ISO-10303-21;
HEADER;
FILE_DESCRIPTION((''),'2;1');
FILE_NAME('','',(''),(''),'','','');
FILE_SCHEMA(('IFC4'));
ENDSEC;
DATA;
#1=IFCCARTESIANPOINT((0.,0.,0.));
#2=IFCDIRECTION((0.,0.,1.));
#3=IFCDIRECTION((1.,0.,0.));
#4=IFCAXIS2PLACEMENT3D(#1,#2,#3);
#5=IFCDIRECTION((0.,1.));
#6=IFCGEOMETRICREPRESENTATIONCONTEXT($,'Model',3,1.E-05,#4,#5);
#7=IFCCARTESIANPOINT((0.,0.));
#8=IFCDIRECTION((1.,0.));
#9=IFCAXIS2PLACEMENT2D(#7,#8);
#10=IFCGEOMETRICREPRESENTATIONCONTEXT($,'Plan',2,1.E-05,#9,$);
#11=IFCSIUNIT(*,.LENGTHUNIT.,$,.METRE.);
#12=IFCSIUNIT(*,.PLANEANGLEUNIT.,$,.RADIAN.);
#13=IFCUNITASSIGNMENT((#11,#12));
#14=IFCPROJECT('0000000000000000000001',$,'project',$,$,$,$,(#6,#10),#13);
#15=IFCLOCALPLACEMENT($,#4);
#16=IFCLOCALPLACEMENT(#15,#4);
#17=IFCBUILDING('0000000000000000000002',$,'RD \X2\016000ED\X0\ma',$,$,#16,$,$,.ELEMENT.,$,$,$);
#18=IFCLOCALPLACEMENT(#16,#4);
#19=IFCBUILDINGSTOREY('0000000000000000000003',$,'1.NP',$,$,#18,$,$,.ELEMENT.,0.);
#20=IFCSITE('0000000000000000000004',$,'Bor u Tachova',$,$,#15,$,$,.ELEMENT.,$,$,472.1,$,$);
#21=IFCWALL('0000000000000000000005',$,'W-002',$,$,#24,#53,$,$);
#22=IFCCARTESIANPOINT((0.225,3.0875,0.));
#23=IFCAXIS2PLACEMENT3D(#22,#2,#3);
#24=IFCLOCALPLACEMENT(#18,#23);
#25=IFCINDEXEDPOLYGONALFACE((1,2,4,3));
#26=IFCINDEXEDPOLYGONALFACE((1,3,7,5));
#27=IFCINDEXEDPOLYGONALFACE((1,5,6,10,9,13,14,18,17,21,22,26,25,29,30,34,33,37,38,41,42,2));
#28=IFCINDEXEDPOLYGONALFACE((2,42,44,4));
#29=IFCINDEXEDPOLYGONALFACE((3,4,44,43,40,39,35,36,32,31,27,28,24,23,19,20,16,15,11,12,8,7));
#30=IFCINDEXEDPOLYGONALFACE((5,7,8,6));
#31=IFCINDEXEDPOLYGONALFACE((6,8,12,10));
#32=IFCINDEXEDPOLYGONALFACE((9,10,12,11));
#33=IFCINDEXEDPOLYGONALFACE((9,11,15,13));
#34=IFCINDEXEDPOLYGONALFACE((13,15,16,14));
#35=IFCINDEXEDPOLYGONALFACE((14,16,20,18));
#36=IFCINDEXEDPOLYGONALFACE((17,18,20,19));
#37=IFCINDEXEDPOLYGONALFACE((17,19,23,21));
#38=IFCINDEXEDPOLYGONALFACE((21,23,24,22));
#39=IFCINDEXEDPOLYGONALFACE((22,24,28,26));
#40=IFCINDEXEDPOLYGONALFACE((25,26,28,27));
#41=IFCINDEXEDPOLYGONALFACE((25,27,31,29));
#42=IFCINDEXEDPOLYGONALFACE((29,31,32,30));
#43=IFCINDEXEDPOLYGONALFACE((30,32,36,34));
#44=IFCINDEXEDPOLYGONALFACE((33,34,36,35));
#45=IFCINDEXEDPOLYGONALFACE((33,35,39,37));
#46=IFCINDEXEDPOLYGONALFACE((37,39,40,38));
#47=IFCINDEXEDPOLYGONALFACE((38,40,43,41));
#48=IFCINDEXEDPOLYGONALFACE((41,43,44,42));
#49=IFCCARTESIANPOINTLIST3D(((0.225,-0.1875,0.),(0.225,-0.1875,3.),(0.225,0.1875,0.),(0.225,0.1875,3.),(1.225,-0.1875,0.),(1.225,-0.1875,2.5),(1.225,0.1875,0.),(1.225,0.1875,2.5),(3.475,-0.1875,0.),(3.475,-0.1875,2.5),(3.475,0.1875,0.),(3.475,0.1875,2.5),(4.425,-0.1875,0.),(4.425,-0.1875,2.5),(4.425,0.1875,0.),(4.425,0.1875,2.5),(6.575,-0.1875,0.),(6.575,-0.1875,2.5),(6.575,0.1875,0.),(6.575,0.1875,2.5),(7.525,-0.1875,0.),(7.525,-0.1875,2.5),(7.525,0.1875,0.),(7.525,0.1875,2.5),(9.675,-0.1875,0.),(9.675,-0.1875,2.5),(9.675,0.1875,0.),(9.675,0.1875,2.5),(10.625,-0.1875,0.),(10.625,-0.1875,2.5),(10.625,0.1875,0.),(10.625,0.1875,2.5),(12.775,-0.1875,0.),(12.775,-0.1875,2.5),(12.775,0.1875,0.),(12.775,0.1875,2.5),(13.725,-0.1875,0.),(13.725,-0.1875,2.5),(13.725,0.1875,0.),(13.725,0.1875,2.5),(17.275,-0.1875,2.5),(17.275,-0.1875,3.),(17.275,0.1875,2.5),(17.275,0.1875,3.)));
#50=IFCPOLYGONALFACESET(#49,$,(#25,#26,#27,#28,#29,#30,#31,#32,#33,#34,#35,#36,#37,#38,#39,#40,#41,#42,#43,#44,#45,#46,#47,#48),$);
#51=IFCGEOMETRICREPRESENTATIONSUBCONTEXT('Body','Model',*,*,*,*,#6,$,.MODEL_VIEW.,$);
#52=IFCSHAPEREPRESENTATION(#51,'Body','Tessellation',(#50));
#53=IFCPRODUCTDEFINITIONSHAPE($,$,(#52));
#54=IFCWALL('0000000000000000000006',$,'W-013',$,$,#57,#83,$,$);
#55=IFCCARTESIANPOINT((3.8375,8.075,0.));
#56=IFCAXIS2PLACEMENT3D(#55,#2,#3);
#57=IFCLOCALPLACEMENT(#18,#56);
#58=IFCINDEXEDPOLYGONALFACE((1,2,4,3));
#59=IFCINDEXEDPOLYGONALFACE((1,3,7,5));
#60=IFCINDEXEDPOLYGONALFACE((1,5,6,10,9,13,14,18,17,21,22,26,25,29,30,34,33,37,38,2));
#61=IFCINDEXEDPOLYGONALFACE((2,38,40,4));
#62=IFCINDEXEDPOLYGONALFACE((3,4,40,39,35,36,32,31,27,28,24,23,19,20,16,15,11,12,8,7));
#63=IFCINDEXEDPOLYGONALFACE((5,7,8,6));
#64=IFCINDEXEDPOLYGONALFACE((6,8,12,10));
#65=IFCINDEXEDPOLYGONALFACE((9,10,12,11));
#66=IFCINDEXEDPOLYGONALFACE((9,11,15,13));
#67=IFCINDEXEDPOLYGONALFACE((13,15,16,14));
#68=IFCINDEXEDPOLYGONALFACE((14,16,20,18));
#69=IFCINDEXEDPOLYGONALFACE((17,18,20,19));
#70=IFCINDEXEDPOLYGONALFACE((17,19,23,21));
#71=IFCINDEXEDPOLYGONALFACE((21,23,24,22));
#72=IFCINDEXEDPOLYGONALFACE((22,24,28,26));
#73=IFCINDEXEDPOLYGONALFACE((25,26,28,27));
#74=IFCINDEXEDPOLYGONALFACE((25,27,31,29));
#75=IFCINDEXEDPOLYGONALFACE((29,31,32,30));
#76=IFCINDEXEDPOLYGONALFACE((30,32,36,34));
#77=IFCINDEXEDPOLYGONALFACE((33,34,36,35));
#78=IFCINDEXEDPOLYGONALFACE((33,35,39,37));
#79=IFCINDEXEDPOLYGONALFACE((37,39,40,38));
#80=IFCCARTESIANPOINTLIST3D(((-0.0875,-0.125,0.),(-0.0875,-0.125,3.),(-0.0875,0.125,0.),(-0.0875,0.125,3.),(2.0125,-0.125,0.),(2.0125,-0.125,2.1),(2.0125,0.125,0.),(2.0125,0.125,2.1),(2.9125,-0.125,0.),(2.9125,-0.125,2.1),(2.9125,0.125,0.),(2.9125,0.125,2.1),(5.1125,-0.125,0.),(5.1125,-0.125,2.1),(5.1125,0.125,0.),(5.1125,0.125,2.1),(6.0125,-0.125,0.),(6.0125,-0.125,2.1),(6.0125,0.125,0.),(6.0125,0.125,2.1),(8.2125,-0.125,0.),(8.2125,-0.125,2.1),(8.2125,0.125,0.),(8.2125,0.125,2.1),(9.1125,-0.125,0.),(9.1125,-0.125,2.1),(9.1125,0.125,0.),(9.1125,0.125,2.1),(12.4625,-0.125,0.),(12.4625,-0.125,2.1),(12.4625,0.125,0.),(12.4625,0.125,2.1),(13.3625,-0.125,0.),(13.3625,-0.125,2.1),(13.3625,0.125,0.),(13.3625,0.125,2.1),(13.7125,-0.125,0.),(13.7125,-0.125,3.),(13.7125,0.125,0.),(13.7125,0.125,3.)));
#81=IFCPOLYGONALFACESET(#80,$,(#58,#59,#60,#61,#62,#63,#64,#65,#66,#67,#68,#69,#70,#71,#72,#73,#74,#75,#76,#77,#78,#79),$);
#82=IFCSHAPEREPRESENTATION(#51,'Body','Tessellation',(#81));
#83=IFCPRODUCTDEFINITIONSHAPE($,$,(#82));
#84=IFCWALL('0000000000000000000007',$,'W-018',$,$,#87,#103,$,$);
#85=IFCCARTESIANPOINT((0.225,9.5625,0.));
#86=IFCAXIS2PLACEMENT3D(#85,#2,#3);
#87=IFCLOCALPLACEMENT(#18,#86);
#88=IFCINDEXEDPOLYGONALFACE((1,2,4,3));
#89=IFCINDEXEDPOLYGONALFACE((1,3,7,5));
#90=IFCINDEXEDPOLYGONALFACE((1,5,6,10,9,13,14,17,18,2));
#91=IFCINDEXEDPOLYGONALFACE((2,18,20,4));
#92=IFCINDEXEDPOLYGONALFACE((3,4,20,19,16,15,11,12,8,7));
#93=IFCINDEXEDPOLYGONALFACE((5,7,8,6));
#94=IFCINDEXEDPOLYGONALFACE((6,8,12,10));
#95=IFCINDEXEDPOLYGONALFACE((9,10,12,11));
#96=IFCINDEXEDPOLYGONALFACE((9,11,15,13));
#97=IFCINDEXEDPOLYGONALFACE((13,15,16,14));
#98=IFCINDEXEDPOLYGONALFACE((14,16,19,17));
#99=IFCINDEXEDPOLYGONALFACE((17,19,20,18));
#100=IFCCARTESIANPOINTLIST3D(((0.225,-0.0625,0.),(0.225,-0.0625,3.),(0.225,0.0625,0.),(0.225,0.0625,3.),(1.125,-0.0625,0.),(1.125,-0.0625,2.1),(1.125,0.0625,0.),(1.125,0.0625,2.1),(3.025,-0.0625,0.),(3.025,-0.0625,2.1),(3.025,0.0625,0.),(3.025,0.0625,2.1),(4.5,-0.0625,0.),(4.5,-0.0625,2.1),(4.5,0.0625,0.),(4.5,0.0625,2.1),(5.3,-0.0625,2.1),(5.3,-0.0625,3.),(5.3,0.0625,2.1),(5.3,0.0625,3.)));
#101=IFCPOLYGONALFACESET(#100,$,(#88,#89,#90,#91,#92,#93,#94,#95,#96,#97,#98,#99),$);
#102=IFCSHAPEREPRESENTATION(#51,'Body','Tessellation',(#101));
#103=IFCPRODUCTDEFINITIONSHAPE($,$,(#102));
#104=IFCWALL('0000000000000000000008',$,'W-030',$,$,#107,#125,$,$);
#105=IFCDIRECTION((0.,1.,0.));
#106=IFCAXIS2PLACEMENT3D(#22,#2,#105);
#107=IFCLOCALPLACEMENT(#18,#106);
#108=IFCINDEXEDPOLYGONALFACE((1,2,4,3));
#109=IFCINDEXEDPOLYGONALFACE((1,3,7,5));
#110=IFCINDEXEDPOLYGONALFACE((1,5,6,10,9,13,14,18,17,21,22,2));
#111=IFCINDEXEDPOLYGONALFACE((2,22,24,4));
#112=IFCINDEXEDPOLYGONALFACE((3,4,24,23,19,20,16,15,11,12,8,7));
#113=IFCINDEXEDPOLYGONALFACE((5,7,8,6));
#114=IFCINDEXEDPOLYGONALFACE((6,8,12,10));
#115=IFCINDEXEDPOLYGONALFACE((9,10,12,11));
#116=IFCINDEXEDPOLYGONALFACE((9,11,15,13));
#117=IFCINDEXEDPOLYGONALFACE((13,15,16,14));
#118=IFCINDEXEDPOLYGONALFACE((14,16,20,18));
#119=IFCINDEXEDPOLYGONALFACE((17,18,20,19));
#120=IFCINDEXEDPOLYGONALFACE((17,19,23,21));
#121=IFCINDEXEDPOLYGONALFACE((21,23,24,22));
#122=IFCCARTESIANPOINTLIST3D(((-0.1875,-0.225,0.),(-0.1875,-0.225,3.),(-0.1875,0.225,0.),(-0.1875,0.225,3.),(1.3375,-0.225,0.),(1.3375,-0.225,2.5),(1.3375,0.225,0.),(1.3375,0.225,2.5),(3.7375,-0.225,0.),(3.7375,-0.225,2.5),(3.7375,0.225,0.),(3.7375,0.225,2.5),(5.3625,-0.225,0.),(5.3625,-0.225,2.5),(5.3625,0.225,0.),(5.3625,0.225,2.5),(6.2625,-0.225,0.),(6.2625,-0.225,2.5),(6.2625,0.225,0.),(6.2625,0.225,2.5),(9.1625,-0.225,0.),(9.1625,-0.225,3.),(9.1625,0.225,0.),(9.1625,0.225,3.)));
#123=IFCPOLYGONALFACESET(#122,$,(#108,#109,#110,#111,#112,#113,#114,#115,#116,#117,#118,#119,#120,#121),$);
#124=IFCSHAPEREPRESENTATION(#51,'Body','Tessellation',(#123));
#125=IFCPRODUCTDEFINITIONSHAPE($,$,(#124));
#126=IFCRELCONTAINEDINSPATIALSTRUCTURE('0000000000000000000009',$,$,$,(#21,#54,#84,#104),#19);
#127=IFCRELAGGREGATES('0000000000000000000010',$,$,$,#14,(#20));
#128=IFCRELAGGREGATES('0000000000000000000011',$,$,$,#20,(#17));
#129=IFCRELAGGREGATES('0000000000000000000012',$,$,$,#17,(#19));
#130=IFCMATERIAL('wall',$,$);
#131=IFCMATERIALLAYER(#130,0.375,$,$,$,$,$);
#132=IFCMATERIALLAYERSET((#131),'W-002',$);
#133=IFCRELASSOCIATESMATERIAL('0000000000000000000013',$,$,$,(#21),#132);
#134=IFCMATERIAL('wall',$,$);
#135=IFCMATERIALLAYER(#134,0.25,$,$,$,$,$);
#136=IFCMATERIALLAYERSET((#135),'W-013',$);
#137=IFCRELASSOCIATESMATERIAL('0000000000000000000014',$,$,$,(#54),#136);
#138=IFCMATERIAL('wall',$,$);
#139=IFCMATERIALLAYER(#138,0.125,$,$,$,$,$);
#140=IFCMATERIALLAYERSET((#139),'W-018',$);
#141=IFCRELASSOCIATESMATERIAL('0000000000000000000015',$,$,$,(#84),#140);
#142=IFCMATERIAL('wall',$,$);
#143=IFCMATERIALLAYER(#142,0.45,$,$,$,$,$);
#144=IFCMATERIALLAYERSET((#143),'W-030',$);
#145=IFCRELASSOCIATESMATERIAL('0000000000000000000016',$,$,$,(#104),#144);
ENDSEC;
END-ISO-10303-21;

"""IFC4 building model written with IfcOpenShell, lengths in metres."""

from ifc_helpers import new_model, si_unit, direction, frame, frame_2d, origin_with_axes, origin_2d_with_axis, place, context, subcontext, project, spatial, line, indexed_curve, rectangle, outline, extrude, material, layer, layer_set, layer_usage, element, save


model = new_model("IFC4")

# Units and contexts
model_context = context("Model", 3, precision=1e-05, world=origin_with_axes(), true_north=direction((0.0, 1.0)))
plan_context = context("Plan", 2, precision=1e-05, world=origin_2d_with_axis())
body_context = subcontext(model_context, "Body", "Model", "MODEL_VIEW")
ifc_project = project(units=[si_unit("LENGTHUNIT", "METRE"), si_unit("PLANEANGLEUNIT", "RADIAN")], contexts=[model_context, plan_context])

# Site, building, storey
site_placement = place(None, origin_with_axes())
site = spatial("IfcSite", under=ifc_project, at=site_placement, Name="Bor u Tachova", CompositionType="ELEMENT", RefElevation=472.1)
building_placement = place(site_placement, origin_with_axes())
building = spatial("IfcBuilding", under=site, at=building_placement, Name="RD Šíma", CompositionType="ELEMENT")
storey_placement = place(building_placement, origin_with_axes())
storey = spatial("IfcBuildingStorey", under=building, at=storey_placement, Name="1.NP", CompositionType="ELEMENT", Elevation=0.0)

# Walls, openings
ifc_material_1 = material(Name="wall")
ifc_layer_1 = layer(ifc_material_1, 0.375)
ifc_layer_set_1 = layer_set([ifc_layer_1], Name="W-002")
ifc_layer_usage_1 = layer_usage(ifc_layer_set_1, "AXIS2", "POSITIVE", -0.1875)
wall_1_placement = place(storey_placement, frame((0.225, 3.0875, 0.0), z_axis=(0.0, 0.0, 1.0), x_axis=(1.0, 0.0, 0.0)))
wall_1 = element("IfcWall", 1, at=wall_1_placement, inside=storey, material=ifc_layer_usage_1, Name="W-002", context=body_context, shape_type="SweptSolid", body=[
    extrude(outline(indexed_curve([(0.225, -0.1875), (0.225, 0.1875), (17.275, 0.1875), (17.275, -0.1875)], segments=[line(1, 2, 3, 4, 1)])), origin_with_axes(), (0.0, 0.0, 1.0), 3.0),
])
opening_1_placement = place(wall_1_placement, frame((1.225, 0.0, 0.0), z_axis=(0.0, 0.0, 1.0), x_axis=(1.0, 0.0, 0.0)))
element("IfcOpeningElement", 2, at=opening_1_placement, cuts=wall_1, PredefinedType="OPENING", context=body_context, shape_type="SweptSolid", body=[
    extrude(rectangle(XDim=2.25, YDim=0.375, at=frame_2d((1.125, 0.0))), origin_with_axes(), (0.0, 0.0, 1.0), 2.5),
])
opening_2_placement = place(wall_1_placement, frame((4.425, 0.0, 0.0), z_axis=(0.0, 0.0, 1.0), x_axis=(1.0, 0.0, 0.0)))
element("IfcOpeningElement", 3, at=opening_2_placement, cuts=wall_1, PredefinedType="OPENING", context=body_context, shape_type="SweptSolid", body=[
    extrude(rectangle(XDim=2.15, YDim=0.375, at=frame_2d((1.075, 0.0))), origin_with_axes(), (0.0, 0.0, 1.0), 2.5),
])
opening_3_placement = place(wall_1_placement, frame((7.525, 0.0, 0.0), z_axis=(0.0, 0.0, 1.0), x_axis=(1.0, 0.0, 0.0)))
element("IfcOpeningElement", 4, at=opening_3_placement, cuts=wall_1, PredefinedType="OPENING", context=body_context, shape_type="SweptSolid", body=[
    extrude(rectangle(XDim=2.15, YDim=0.375, at=frame_2d((1.075, 0.0))), origin_with_axes(), (0.0, 0.0, 1.0), 2.5),
])
opening_4_placement = place(wall_1_placement, frame((10.625, 0.0, 0.0), z_axis=(0.0, 0.0, 1.0), x_axis=(1.0, 0.0, 0.0)))
element("IfcOpeningElement", 5, at=opening_4_placement, cuts=wall_1, PredefinedType="OPENING", context=body_context, shape_type="SweptSolid", body=[
    extrude(rectangle(XDim=2.15, YDim=0.375, at=frame_2d((1.075, 0.0))), origin_with_axes(), (0.0, 0.0, 1.0), 2.5),
])
opening_5_placement = place(wall_1_placement, frame((13.725, 0.0, 0.0), z_axis=(0.0, 0.0, 1.0), x_axis=(1.0, 0.0, 0.0)))
element("IfcOpeningElement", 6, at=opening_5_placement, cuts=wall_1, PredefinedType="OPENING", context=body_context, shape_type="SweptSolid", body=[
    extrude(rectangle(XDim=3.55, YDim=0.375, at=frame_2d((1.775, 0.0))), origin_with_axes(), (0.0, 0.0, 1.0), 2.5),
])
ifc_material_2 = material(Name="wall")
ifc_layer_2 = layer(ifc_material_2, 0.25)
ifc_layer_set_2 = layer_set([ifc_layer_2], Name="W-013")
ifc_layer_usage_2 = layer_usage(ifc_layer_set_2, "AXIS2", "POSITIVE", -0.125)
wall_2_placement = place(storey_placement, frame((3.8375, 8.075, 0.0), z_axis=(0.0, 0.0, 1.0), x_axis=(1.0, 0.0, 0.0)))
wall_2 = element("IfcWall", 7, at=wall_2_placement, inside=storey, material=ifc_layer_usage_2, Name="W-013", context=body_context, shape_type="SweptSolid", body=[
    extrude(outline(indexed_curve([(0.0875, -0.125), (-0.0875, -0.125), (-0.0875, 0.125), (13.7125, 0.125), (13.7125, -0.125)], segments=[line(1, 2, 3, 4, 5, 1)])), origin_with_axes(), (0.0, 0.0, 1.0), 3.0),
])
opening_6_placement = place(wall_2_placement, frame((2.0125, 0.0, 0.0), z_axis=(0.0, 0.0, 1.0), x_axis=(1.0, 0.0, 0.0)))
element("IfcOpeningElement", 8, at=opening_6_placement, cuts=wall_2, PredefinedType="OPENING", context=body_context, shape_type="SweptSolid", body=[
    extrude(rectangle(XDim=0.9, YDim=0.25, at=frame_2d((0.45, 0.0))), origin_with_axes(), (0.0, 0.0, 1.0), 2.1),
])
opening_7_placement = place(wall_2_placement, frame((5.1125, 0.0, 0.0), z_axis=(0.0, 0.0, 1.0), x_axis=(1.0, 0.0, 0.0)))
element("IfcOpeningElement", 9, at=opening_7_placement, cuts=wall_2, PredefinedType="OPENING", context=body_context, shape_type="SweptSolid", body=[
    extrude(rectangle(XDim=0.9, YDim=0.25, at=frame_2d((0.45, 0.0))), origin_with_axes(), (0.0, 0.0, 1.0), 2.1),
])
opening_8_placement = place(wall_2_placement, frame((8.2125, 0.0, 0.0), z_axis=(0.0, 0.0, 1.0), x_axis=(1.0, 0.0, 0.0)))
element("IfcOpeningElement", 10, at=opening_8_placement, cuts=wall_2, PredefinedType="OPENING", context=body_context, shape_type="SweptSolid", body=[
    extrude(rectangle(XDim=0.9, YDim=0.25, at=frame_2d((0.45, 0.0))), origin_with_axes(), (0.0, 0.0, 1.0), 2.1),
])
opening_9_placement = place(wall_2_placement, frame((12.4625, 0.0, 0.0), z_axis=(0.0, 0.0, 1.0), x_axis=(1.0, 0.0, 0.0)))
element("IfcOpeningElement", 11, at=opening_9_placement, cuts=wall_2, PredefinedType="OPENING", context=body_context, shape_type="SweptSolid", body=[
    extrude(rectangle(XDim=0.9, YDim=0.25, at=frame_2d((0.45, 0.0))), origin_with_axes(), (0.0, 0.0, 1.0), 2.1),
])
ifc_material_3 = material(Name="wall")
ifc_layer_3 = layer(ifc_material_3, 0.125)
ifc_layer_set_3 = layer_set([ifc_layer_3], Name="W-018")
ifc_layer_usage_3 = layer_usage(ifc_layer_set_3, "AXIS2", "POSITIVE", -0.0625)
wall_3_placement = place(storey_placement, frame((0.225, 9.5625, 0.0), z_axis=(0.0, 0.0, 1.0), x_axis=(1.0, 0.0, 0.0)))
wall_3 = element("IfcWall", 12, at=wall_3_placement, inside=storey, material=ifc_layer_usage_3, Name="W-018", context=body_context, shape_type="SweptSolid", body=[
    extrude(outline(indexed_curve([(0.225, -0.0625), (0.225, 0.0625), (5.3, 0.0625), (5.3, -0.0625)], segments=[line(1, 2, 3, 4, 1)])), origin_with_axes(), (0.0, 0.0, 1.0), 3.0),
])
opening_10_placement = place(wall_3_placement, frame((1.125, 0.0, 0.0), z_axis=(0.0, 0.0, 1.0), x_axis=(1.0, 0.0, 0.0)))
element("IfcOpeningElement", 13, at=opening_10_placement, cuts=wall_3, PredefinedType="OPENING", context=body_context, shape_type="SweptSolid", body=[
    extrude(rectangle(XDim=1.9, YDim=0.125, at=frame_2d((0.95, 0.0))), origin_with_axes(), (0.0, 0.0, 1.0), 2.1),
])
opening_11_placement = place(wall_3_placement, frame((4.5, 0.0, 0.0), z_axis=(0.0, 0.0, 1.0), x_axis=(1.0, 0.0, 0.0)))
element("IfcOpeningElement", 14, at=opening_11_placement, cuts=wall_3, PredefinedType="OPENING", context=body_context, shape_type="SweptSolid", body=[
    extrude(rectangle(XDim=0.8, YDim=0.125, at=frame_2d((0.4, 0.0))), origin_with_axes(), (0.0, 0.0, 1.0), 2.1),
])
ifc_material_4 = material(Name="wall")
ifc_layer_4 = layer(ifc_material_4, 0.45)
ifc_layer_set_4 = layer_set([ifc_layer_4], Name="W-030")
ifc_layer_usage_4 = layer_usage(ifc_layer_set_4, "AXIS2", "POSITIVE", -0.225)
wall_4_placement = place(storey_placement, frame((0.225, 3.0875, 0.0), z_axis=(0.0, 0.0, 1.0), x_axis=(0.0, 1.0, 0.0)))
wall_4 = element("IfcWall", 15, at=wall_4_placement, inside=storey, material=ifc_layer_usage_4, Name="W-030", context=body_context, shape_type="SweptSolid", body=[
    extrude(outline(indexed_curve([(0.1875, -0.225), (-0.1875, -0.225), (-0.1875, 0.225), (9.1625, 0.225), (9.1625, -0.225)], segments=[line(1, 2, 3, 4, 5, 1)])), origin_with_axes(), (0.0, 0.0, 1.0), 3.0),
])
opening_12_placement = place(wall_4_placement, frame((1.3375, 0.0, 0.0), z_axis=(0.0, 0.0, 1.0), x_axis=(1.0, 0.0, 0.0)))
element("IfcOpeningElement", 16, at=opening_12_placement, cuts=wall_4, PredefinedType="OPENING", context=body_context, shape_type="SweptSolid", body=[
    extrude(rectangle(XDim=2.4, YDim=0.45, at=frame_2d((1.2, 0.0))), origin_with_axes(), (0.0, 0.0, 1.0), 2.5),
])
opening_13_placement = place(wall_4_placement, frame((5.3625, 0.0, 0.0), z_axis=(0.0, 0.0, 1.0), x_axis=(1.0, 0.0, 0.0)))
element("IfcOpeningElement", 17, at=opening_13_placement, cuts=wall_4, PredefinedType="OPENING", context=body_context, shape_type="SweptSolid", body=[
    extrude(rectangle(XDim=0.9, YDim=0.45, at=frame_2d((0.45, 0.0))), origin_with_axes(), (0.0, 0.0, 1.0), 2.5),
])

save(model, "model.ifc")
